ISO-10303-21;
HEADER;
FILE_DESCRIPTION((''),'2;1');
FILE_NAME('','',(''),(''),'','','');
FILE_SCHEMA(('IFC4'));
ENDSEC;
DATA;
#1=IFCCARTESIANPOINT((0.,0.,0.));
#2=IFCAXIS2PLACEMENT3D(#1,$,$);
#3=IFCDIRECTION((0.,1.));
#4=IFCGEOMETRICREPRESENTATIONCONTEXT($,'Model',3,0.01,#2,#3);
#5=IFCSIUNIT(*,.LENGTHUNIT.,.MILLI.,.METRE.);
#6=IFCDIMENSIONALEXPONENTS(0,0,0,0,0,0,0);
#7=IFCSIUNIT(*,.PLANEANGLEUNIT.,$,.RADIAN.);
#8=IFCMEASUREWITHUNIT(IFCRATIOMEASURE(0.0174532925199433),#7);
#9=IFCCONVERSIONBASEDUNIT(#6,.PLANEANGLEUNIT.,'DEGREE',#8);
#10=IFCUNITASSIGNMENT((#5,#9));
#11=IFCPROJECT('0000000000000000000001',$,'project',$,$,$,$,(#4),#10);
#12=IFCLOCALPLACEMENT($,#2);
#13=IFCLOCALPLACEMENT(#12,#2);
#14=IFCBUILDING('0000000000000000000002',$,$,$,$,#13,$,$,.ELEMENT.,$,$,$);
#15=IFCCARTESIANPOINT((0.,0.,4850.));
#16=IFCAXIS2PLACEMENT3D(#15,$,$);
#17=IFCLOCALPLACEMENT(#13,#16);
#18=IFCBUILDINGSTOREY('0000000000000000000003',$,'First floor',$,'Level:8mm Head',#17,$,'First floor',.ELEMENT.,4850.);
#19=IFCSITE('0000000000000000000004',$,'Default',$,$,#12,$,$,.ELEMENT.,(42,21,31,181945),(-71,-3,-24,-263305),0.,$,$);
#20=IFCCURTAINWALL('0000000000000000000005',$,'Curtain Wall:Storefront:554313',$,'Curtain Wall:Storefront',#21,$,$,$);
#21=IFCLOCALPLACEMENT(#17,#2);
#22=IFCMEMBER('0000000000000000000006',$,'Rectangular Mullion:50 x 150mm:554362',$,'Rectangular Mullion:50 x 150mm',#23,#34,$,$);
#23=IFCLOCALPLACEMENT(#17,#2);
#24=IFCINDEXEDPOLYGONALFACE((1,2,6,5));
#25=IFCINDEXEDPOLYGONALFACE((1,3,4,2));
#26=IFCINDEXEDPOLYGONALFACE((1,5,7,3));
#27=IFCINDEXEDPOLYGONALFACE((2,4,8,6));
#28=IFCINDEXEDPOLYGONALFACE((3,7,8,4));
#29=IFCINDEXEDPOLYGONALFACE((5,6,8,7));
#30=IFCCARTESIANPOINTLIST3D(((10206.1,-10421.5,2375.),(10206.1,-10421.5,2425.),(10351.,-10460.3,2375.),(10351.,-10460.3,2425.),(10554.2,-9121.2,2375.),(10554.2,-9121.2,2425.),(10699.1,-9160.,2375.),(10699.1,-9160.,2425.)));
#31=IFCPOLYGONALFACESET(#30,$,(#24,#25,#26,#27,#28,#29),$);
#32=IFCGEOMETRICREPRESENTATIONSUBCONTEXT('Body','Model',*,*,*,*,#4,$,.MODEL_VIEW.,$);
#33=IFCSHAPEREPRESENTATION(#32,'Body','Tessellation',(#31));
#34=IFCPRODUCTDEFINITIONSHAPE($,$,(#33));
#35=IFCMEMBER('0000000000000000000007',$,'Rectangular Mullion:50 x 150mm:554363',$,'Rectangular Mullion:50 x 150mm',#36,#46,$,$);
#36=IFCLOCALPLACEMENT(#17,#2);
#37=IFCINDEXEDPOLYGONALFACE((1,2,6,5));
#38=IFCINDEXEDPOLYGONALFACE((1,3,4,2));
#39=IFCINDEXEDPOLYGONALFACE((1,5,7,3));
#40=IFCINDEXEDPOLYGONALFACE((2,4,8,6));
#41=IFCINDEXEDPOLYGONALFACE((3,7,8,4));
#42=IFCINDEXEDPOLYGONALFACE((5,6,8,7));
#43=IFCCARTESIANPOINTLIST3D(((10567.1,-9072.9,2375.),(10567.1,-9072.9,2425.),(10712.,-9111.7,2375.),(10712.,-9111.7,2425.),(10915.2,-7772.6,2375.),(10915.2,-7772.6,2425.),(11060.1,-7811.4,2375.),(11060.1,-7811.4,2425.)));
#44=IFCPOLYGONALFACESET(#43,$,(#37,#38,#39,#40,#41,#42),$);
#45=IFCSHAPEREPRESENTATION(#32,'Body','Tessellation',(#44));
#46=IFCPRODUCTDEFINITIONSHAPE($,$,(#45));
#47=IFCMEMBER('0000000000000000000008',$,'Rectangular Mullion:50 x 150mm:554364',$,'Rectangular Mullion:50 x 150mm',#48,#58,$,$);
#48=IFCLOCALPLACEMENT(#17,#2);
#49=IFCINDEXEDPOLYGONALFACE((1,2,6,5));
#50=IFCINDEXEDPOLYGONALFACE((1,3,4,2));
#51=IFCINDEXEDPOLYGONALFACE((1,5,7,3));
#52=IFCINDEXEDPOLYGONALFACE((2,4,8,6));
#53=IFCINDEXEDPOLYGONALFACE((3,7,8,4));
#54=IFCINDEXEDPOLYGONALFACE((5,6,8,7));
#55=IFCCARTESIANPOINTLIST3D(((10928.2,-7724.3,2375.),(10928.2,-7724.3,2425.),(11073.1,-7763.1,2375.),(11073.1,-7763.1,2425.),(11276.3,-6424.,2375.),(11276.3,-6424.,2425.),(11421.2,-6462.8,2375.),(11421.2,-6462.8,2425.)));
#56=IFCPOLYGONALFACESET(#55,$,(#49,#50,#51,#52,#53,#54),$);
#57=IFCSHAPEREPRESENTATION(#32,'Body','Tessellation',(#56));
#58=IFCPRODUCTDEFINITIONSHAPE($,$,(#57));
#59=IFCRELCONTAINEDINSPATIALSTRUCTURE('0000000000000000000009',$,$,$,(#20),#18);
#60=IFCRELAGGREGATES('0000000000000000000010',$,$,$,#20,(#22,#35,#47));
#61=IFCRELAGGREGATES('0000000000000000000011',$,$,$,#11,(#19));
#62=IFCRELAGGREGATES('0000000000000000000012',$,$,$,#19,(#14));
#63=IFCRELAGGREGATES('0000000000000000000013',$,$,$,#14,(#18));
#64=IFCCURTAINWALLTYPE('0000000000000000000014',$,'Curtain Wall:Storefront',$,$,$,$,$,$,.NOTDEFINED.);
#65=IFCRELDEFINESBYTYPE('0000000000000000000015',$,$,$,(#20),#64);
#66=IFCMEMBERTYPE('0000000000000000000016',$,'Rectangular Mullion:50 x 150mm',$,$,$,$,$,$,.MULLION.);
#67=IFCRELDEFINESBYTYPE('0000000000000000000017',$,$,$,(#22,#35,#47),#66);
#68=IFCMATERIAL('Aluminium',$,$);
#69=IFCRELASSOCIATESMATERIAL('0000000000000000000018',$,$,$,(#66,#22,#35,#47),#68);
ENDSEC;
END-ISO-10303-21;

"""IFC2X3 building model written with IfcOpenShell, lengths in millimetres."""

from ifc_helpers import new_model, entity, si_unit, converted_unit, direction, frame, origin, origin_2d_with_axis, place, context, subcontext, project, spatial, rectangle, extrude, source, transform, mapped, material, type_object, type_shapes, element, aggregate, save


model = new_model("IFC2X3")

# Units and contexts
model_context = context("Model", 3, precision=0.01, world=origin(), true_north=direction((0.0, 1.0)))
body_context = subcontext(model_context, "Body", "Model", "MODEL_VIEW")
ifc_project = project(units=[si_unit("LENGTHUNIT", "METRE", prefix="MILLI"), converted_unit("PLANEANGLEUNIT", "DEGREE", entity("IfcRatioMeasure", 0.0174532925199433), si_unit("PLANEANGLEUNIT", "RADIAN"), dimensions=[0, 0, 0, 0, 0, 0, 0])], contexts=[model_context])

# Site, building, storey
site_placement = place(None, origin())
site = spatial("IfcSite", under=ifc_project, at=site_placement, Name="Default", CompositionType="ELEMENT", RefLatitude=(42, 21, 31, 181945), RefLongitude=(-71, -3, -24, -263305), RefElevation=0.0)
building_placement = place(site_placement, origin())
building = spatial("IfcBuilding", under=site, at=building_placement, CompositionType="ELEMENT")
storey_placement = place(building_placement, frame((0.0, 0.0, 4850.0)))
storey = spatial("IfcBuildingStorey", under=building, at=storey_placement, Name="First floor", ObjectType="Level:8mm Head", LongName="First floor", CompositionType="ELEMENT", Elevation=4850.0)

# Curtain wall, members
curtain_wall_type = type_object("IfcCurtainWallType", Name="Curtain Wall:Storefront", PredefinedType="NOTDEFINED")
curtain_wall_placement = place(storey_placement, frame((0.0, 0.0, -4850.0)))
curtain_wall = element("IfcCurtainWall", 1, at=curtain_wall_placement, inside=storey, type_object=curtain_wall_type, Name="Curtain Wall:Storefront:554313", ObjectType="Curtain Wall:Storefront")
ifc_material_1 = material(Name="Aluminium")
member_type_1 = type_object("IfcMemberType", Name="Rectangular Mullion:50 x 150mm", PredefinedType="MULLION", material=ifc_material_1)
shared_shape_1 = source(origin(), body_context, "Body", "SweptSolid", [
    extrude(rectangle(XDim=150.0, YDim=50.0, at=origin_2d_with_axis()), frame((0.0, 0.0, -1346.1), z_axis=(0.0, 0.0, 1.0), x_axis=(0.0, -1.0, 0.0)), (0.0, 0.0, 1.0), 1346.1),
])
type_shapes(member_type_1, [shared_shape_1])
member_1_placement = place(storey_placement, frame((10626.7, -9140.6, 2400.0), z_axis=(0.258607, 0.965983, 0.0), x_axis=(0.0, 0.0, 1.0)))
member_1 = element("IfcMember", 2, at=member_1_placement, type_object=member_type_1, material=ifc_material_1, Name="Rectangular Mullion:50 x 150mm:554362", ObjectType="Rectangular Mullion:50 x 150mm", context=body_context, shape_type="MappedRepresentation", body=[
    mapped(shared_shape_1, transform((0.0, 0.0, 0.0), scale=1.0)),
])
member_2_placement = place(storey_placement, frame((10987.7, -7792.0, 2400.0), z_axis=(0.258607, 0.965983, 0.0), x_axis=(0.0, 0.0, 1.0)))
member_2 = element("IfcMember", 3, at=member_2_placement, type_object=member_type_1, material=ifc_material_1, Name="Rectangular Mullion:50 x 150mm:554363", ObjectType="Rectangular Mullion:50 x 150mm", context=body_context, shape_type="MappedRepresentation", body=[
    mapped(shared_shape_1, transform((0.0, 0.0, 0.0), scale=1.0)),
])
member_3_placement = place(storey_placement, frame((11348.7, -6443.4, 2400.0), z_axis=(0.258607, 0.965983, 0.0), x_axis=(0.0, 0.0, 1.0)))
member_3 = element("IfcMember", 4, at=member_3_placement, type_object=member_type_1, material=ifc_material_1, Name="Rectangular Mullion:50 x 150mm:554364", ObjectType="Rectangular Mullion:50 x 150mm", context=body_context, shape_type="MappedRepresentation", body=[
    mapped(shared_shape_1, transform((0.0, 0.0, 0.0), scale=1.0)),
])
aggregate(curtain_wall, [member_1, member_2, member_3])

save(model, "model.ifc")
